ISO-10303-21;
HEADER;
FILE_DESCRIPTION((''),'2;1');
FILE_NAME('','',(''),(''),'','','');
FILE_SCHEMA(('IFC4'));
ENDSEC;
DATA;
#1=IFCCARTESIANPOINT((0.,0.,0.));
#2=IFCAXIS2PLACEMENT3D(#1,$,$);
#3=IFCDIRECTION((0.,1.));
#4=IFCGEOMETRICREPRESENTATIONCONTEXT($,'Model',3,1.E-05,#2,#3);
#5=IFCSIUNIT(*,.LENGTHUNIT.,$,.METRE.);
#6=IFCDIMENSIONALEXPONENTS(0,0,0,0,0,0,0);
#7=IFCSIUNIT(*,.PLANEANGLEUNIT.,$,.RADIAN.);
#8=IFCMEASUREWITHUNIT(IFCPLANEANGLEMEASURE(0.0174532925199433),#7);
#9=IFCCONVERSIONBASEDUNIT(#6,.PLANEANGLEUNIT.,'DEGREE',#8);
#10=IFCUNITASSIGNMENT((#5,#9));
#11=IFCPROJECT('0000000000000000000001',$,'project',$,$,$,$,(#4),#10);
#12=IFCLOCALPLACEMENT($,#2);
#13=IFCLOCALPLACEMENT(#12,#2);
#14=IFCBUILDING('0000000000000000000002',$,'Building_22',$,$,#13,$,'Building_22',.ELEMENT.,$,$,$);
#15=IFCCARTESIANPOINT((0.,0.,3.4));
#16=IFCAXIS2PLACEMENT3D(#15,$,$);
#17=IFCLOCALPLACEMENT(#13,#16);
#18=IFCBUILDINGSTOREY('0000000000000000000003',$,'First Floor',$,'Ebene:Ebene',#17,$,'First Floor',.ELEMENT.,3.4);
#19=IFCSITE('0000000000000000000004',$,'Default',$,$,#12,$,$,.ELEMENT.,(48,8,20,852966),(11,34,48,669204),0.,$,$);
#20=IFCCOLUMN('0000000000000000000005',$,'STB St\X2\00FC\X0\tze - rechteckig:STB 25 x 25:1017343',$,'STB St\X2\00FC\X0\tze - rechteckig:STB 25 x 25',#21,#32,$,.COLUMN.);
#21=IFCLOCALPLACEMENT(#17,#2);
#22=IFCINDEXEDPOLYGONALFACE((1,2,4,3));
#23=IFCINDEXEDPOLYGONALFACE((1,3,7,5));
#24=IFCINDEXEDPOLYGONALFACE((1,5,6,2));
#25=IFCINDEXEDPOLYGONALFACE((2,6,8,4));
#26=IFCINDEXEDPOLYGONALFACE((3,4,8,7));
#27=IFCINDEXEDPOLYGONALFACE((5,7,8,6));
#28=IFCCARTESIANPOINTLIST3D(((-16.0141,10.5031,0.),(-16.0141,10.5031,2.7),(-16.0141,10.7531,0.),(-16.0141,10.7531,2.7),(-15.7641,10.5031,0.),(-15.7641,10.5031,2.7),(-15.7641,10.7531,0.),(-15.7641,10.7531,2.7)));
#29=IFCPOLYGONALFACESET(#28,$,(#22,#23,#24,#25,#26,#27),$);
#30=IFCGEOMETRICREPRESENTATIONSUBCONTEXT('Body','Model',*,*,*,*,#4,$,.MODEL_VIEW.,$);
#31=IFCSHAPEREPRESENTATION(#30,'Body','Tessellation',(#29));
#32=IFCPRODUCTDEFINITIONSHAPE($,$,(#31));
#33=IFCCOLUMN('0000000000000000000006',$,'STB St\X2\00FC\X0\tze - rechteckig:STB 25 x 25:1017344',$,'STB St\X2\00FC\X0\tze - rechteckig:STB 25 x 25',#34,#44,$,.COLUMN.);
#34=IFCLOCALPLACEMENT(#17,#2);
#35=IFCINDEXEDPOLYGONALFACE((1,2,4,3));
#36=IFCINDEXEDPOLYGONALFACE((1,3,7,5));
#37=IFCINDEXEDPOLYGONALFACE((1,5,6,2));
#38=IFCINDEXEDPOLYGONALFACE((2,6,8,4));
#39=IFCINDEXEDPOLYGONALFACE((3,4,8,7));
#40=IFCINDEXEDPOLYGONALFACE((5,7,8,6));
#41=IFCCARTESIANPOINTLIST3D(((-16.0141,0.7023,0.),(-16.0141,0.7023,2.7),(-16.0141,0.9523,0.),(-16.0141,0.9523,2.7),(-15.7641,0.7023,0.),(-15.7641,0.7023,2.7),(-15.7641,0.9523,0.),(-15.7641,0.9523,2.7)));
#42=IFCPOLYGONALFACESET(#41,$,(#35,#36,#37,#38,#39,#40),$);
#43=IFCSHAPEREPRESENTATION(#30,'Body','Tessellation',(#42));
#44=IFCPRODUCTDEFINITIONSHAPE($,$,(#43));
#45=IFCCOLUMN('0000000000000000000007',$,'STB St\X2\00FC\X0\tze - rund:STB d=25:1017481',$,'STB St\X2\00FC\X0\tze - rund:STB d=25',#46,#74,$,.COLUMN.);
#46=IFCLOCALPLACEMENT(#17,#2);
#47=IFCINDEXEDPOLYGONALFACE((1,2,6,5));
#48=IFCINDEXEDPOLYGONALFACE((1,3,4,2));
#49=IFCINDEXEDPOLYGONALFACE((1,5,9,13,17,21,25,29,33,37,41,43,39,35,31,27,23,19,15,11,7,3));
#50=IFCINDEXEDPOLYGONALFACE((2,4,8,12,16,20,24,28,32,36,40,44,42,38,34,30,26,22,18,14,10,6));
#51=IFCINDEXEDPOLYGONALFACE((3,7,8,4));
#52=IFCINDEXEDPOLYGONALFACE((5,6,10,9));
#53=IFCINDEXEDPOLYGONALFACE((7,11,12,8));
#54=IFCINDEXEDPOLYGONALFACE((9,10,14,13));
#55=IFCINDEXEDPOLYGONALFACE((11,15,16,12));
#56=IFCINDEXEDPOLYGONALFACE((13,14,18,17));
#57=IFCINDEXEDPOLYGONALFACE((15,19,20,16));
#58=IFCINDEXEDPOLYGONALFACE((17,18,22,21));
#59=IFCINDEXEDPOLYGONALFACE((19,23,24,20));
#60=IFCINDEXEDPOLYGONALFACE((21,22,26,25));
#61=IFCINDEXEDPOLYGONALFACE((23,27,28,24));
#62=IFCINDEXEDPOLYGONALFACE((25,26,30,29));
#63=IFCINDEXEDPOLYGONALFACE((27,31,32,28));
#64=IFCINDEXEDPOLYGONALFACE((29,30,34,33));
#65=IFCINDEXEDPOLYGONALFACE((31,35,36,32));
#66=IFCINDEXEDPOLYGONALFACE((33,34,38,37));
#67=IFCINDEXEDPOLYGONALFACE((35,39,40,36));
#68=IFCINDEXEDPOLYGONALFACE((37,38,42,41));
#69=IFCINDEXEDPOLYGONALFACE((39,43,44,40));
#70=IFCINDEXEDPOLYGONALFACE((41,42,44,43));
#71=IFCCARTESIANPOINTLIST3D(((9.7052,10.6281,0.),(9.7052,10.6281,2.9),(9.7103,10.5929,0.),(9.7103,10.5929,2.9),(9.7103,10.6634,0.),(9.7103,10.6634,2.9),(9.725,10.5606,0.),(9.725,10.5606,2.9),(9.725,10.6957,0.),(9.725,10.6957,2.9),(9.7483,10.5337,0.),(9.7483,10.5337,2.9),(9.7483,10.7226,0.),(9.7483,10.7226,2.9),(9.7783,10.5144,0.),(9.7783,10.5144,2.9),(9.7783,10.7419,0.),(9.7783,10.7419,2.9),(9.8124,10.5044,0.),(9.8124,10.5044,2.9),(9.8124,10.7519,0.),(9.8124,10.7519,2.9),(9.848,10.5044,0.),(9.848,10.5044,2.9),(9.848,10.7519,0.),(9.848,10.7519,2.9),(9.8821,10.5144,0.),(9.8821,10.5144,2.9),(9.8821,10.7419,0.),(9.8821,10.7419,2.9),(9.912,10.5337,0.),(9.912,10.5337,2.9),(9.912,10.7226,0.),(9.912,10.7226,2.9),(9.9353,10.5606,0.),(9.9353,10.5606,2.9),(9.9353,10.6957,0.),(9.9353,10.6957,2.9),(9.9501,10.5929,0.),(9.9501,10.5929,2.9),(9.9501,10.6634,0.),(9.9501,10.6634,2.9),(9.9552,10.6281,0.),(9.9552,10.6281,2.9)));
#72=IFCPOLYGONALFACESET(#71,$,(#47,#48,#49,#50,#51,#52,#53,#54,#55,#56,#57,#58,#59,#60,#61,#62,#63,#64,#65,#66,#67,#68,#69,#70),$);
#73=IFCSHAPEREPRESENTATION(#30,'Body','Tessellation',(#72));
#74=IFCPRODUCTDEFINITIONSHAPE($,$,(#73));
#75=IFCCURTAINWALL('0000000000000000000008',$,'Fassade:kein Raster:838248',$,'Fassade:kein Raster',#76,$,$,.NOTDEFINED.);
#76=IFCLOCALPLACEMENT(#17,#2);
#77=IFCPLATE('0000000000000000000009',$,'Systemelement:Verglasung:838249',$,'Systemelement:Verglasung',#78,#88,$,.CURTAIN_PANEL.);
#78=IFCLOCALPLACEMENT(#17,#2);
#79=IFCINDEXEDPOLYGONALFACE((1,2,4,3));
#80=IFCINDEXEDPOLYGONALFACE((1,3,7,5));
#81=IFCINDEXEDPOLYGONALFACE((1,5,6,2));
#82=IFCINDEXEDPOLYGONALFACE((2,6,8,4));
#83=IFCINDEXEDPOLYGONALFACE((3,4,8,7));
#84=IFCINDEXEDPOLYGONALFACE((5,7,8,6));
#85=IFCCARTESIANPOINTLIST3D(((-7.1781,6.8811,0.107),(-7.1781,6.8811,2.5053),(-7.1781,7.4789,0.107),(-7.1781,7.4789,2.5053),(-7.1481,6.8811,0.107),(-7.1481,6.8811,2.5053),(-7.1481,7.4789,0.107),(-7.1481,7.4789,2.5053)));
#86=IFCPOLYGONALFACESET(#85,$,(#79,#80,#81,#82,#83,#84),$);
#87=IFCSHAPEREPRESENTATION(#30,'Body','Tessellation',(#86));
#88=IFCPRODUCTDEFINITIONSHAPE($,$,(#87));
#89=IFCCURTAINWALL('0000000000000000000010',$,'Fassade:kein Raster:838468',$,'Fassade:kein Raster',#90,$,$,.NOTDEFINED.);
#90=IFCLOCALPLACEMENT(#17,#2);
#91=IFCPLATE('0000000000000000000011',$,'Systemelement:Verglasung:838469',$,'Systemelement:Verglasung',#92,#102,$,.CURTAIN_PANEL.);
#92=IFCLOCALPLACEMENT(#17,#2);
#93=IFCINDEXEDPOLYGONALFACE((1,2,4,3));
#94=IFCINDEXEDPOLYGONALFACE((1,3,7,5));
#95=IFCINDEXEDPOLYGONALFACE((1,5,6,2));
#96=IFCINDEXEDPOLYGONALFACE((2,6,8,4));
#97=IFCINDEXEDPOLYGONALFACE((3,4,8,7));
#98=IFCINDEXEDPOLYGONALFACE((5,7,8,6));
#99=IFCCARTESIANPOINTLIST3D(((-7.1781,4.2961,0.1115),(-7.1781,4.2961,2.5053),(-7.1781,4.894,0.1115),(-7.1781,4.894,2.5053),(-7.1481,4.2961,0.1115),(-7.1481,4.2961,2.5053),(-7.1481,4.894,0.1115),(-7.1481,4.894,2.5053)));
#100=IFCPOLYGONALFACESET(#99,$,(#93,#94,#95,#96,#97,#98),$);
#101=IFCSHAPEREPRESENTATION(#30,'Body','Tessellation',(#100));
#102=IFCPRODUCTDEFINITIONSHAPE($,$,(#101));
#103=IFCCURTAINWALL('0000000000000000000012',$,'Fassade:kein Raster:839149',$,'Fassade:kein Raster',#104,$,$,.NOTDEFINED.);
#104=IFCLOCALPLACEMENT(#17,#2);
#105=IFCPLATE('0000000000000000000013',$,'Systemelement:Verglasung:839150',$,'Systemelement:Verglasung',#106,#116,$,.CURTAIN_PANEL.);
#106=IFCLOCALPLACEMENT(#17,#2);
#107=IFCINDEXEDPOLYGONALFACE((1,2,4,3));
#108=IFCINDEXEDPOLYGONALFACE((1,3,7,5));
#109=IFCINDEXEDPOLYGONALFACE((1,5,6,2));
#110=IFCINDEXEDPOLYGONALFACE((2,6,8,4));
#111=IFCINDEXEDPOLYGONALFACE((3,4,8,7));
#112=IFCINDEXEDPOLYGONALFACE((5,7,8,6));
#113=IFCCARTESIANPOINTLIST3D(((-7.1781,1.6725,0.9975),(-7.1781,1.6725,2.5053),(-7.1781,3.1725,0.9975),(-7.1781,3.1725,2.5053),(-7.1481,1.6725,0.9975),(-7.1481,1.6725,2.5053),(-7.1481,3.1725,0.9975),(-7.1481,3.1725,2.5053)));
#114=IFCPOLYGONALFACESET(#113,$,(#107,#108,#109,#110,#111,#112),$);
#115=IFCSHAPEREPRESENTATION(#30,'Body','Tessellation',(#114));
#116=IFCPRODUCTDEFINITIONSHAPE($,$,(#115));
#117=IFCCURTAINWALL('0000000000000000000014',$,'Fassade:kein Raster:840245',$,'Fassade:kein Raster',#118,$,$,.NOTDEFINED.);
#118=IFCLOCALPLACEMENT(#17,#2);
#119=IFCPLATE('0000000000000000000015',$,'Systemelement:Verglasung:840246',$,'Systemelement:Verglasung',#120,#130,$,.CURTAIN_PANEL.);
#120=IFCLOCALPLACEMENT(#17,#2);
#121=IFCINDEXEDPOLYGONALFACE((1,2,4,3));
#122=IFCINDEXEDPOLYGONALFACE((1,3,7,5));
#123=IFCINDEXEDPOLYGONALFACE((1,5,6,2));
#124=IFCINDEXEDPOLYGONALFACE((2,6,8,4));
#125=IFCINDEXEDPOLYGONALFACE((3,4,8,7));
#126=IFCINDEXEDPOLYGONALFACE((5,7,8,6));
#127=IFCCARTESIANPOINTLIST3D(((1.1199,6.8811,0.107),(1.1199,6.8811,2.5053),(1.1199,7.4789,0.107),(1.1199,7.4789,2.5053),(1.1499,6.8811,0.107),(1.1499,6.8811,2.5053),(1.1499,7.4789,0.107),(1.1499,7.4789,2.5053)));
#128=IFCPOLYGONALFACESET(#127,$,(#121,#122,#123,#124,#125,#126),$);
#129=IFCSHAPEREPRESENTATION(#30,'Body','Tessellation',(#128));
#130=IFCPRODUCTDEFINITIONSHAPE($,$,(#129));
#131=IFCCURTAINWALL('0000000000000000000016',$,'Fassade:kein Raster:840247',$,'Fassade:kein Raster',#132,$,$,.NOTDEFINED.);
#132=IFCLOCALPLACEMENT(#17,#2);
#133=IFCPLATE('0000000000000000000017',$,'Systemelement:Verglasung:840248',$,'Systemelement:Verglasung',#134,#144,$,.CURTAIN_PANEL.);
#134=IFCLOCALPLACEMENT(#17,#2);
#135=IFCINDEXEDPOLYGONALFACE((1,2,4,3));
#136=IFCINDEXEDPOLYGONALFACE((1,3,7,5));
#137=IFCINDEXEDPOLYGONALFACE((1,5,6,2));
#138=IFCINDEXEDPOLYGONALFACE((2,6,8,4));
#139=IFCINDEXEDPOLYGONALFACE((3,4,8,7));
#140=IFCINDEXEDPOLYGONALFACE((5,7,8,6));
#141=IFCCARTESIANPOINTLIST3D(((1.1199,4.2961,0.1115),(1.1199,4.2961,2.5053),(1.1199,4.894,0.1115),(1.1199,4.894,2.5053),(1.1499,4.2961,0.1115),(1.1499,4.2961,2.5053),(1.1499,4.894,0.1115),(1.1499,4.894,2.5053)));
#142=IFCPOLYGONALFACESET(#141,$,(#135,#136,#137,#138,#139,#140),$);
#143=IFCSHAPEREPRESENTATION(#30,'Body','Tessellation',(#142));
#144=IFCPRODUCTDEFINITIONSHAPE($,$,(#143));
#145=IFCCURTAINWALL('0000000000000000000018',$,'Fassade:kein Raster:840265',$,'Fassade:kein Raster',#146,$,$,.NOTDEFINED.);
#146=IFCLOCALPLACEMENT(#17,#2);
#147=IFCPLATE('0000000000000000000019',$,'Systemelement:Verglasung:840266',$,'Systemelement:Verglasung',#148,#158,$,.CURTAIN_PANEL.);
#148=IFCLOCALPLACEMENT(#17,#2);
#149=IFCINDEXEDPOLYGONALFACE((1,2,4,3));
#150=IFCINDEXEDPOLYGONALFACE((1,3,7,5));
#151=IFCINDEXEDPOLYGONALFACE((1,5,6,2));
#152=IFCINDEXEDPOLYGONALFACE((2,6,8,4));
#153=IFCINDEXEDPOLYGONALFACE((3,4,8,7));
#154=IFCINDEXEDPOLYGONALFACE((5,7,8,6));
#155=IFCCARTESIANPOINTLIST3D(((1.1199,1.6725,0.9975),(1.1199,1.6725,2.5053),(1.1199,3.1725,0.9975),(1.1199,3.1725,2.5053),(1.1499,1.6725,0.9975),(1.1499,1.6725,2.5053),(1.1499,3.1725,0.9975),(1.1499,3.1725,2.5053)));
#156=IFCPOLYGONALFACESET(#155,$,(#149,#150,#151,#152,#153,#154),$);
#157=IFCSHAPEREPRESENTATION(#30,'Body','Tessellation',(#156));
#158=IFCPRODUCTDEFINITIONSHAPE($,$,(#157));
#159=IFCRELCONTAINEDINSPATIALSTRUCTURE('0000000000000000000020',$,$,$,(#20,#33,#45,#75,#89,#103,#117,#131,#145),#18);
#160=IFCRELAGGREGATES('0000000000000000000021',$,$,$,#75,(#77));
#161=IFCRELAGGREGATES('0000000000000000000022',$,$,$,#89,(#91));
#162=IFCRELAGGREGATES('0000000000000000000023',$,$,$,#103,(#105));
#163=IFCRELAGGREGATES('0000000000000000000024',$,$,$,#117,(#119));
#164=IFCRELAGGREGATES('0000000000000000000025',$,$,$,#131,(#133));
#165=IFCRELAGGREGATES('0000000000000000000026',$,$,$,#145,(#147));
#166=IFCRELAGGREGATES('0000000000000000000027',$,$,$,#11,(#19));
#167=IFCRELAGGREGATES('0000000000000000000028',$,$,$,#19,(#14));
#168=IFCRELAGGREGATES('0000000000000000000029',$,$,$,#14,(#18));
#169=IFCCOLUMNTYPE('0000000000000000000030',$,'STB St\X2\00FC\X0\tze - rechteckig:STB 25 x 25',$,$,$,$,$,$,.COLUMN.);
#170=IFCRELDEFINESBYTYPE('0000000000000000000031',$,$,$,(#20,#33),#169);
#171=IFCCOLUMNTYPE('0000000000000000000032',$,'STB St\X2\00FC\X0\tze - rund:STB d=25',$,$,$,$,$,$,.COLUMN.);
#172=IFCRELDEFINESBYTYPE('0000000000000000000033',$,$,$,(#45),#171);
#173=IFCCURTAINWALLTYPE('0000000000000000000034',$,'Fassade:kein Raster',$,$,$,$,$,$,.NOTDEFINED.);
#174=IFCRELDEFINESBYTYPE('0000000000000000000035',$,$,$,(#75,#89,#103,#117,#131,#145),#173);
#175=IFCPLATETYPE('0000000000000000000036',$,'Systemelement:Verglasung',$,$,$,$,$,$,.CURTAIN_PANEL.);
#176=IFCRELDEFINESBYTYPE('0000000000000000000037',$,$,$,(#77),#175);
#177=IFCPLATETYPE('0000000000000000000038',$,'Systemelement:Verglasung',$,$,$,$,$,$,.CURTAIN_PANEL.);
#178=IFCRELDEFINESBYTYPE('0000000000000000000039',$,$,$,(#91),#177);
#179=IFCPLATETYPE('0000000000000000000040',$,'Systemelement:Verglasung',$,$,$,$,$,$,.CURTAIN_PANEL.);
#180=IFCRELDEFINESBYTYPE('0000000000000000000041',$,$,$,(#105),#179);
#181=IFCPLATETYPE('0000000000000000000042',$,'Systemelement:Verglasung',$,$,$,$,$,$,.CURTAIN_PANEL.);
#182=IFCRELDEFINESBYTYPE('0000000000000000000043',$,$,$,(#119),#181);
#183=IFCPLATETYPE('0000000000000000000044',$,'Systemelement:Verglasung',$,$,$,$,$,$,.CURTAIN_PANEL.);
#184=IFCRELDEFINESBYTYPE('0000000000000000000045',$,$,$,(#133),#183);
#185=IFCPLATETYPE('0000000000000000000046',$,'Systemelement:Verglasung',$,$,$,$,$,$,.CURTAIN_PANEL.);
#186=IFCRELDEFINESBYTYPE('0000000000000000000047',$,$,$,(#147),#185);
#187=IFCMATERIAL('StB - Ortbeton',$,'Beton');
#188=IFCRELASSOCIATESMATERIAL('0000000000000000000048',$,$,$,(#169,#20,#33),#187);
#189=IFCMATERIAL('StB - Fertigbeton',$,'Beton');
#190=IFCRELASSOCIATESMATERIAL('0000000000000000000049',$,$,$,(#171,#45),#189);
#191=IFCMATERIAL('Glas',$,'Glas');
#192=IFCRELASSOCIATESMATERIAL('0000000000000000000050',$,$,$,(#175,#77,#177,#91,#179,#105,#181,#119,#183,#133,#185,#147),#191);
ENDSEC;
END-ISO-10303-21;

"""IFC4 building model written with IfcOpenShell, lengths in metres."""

from ifc_helpers import new_model, entity, si_unit, converted_unit, direction, frame, origin, place, context, subcontext, project, spatial, arc, indexed_curve, outline, extrude, source, transform, mapped, material, type_object, type_shapes, element, aggregate, save


model = new_model("IFC4")

# Units and contexts
model_context = context("Model", 3, precision=1e-05, world=origin(), true_north=direction((0.0, 1.0)))
body_context = subcontext(model_context, "Body", "Model", "MODEL_VIEW")
ifc_project = project(units=[si_unit("LENGTHUNIT", "METRE"), converted_unit("PLANEANGLEUNIT", "DEGREE", entity("IfcPlaneAngleMeasure", 0.0174532925199433), si_unit("PLANEANGLEUNIT", "RADIAN"), dimensions=[0, 0, 0, 0, 0, 0, 0])], contexts=[model_context])

# Site, building, storey
site_placement = place(None, origin())
site = spatial("IfcSite", under=ifc_project, at=site_placement, Name="Default", CompositionType="ELEMENT", RefLatitude=(48, 8, 20, 852966), RefLongitude=(11, 34, 48, 669204), RefElevation=0.0)
building_placement = place(site_placement, origin())
building = spatial("IfcBuilding", under=site, at=building_placement, Name="Building_22", LongName="Building_22", CompositionType="ELEMENT")
storey_placement = place(building_placement, frame((0.0, 0.0, 3.4)))
storey = spatial("IfcBuildingStorey", under=building, at=storey_placement, Name="First Floor", ObjectType="Ebene:Ebene", LongName="First Floor", CompositionType="ELEMENT", Elevation=3.4)

# Columns
ifc_material_1 = material(Name="StB - Ortbeton", Category="Beton")
column_type_1 = type_object("IfcColumnType", Name="STB Stütze - rechteckig:STB 25 x 25", PredefinedType="COLUMN", material=ifc_material_1)
shared_shape_1 = source(origin(), body_context, "Body", "SweptSolid", [
    extrude(outline(indexed_curve([(-0.125, -0.125), (0.125, -0.125), (0.125, 0.125), (-0.125, 0.125), (-0.125, -0.125)], self_intersect=False)), frame((0.0, 0.0, 3.4), z_axis=(0.0, 0.0, 1.0), x_axis=(-1.0, 0.0, 0.0)), (0.0, 0.0, 1.0), 2.7),
])
type_shapes(column_type_1, [shared_shape_1])
for number, where, name in (
    (1, (-15.8891, 10.6281, -3.4), "STB Stütze - rechteckig:STB 25 x 25:1017343"),
    (2, (-15.8891, 0.8273, -3.4), "STB Stütze - rechteckig:STB 25 x 25:1017344"),
):
    element("IfcColumn", number, at=place(storey_placement, frame(where)), inside=storey, type_object=column_type_1, material=ifc_material_1, Name=name, ObjectType="STB Stütze - rechteckig:STB 25 x 25", PredefinedType="COLUMN", context=body_context, shape_type="MappedRepresentation", body=[
        mapped(shared_shape_1, transform((0.0, 0.0, 0.0), scale=1.0)),
    ])
ifc_material_2 = material(Name="StB - Fertigbeton", Category="Beton")
column_type_2 = type_object("IfcColumnType", Name="STB Stütze - rund:STB d=25", PredefinedType="COLUMN", material=ifc_material_2)
shared_shape_2 = source(origin(), body_context, "Body", "SweptSolid", [
    extrude(outline(indexed_curve([(-0.125, 0.0), (0.0, -0.125), (0.125, 0.0), (0.0, 0.125)], segments=[arc(1, 2, 3), arc(3, 4, 1)], self_intersect=False)), frame((0.0, 0.0, 3.4)), (0.0, 0.0, 1.0), 2.9),
])
type_shapes(column_type_2, [shared_shape_2])
column_placement = place(storey_placement, frame((9.8302, 10.6281, -3.4), z_axis=(0.0, 0.0, 1.0), x_axis=(-1.0, 0.0, 0.0)))
element("IfcColumn", 3, at=column_placement, inside=storey, type_object=column_type_2, material=ifc_material_2, Name="STB Stütze - rund:STB d=25:1017481", ObjectType="STB Stütze - rund:STB d=25", PredefinedType="COLUMN", context=body_context, shape_type="MappedRepresentation", body=[
    mapped(shared_shape_2, transform((0.0, 0.0, 0.0), scale=1.0)),
])

# Curtain walls, plates
curtain_wall_type = type_object("IfcCurtainWallType", Name="Fassade:kein Raster", PredefinedType="NOTDEFINED")
curtain_wall_1_placement = place(storey_placement, frame((0.0, 0.0, -3.4)))
curtain_wall_1 = element("IfcCurtainWall", 4, at=curtain_wall_1_placement, inside=storey, type_object=curtain_wall_type, Name="Fassade:kein Raster:838248", ObjectType="Fassade:kein Raster", PredefinedType="NOTDEFINED")
ifc_material_3 = material(Name="Glas", Category="Glas")
plate_type_1 = type_object("IfcPlateType", Name="Systemelement:Verglasung", PredefinedType="CURTAIN_PANEL", material=ifc_material_3)
shared_shape_3 = source(origin(), body_context, "Body", "SweptSolid", [
    extrude(outline(indexed_curve([(-0.015, -0.2989), (0.015, -0.2989), (0.015, 0.2989), (-0.015, 0.2989), (-0.015, -0.2989)], self_intersect=False)), frame((0.0, 0.0, 0.0), z_axis=(0.0, 0.0, 1.0), x_axis=(0.0, 1.0, 0.0)), (0.0, 0.0, 1.0), 2.3983),
])
type_shapes(plate_type_1, [shared_shape_3])
plate_1_placement = place(curtain_wall_1_placement, frame((-7.1631, 7.18, 3.507), z_axis=(0.0, 0.0, 1.0), x_axis=(0.0, -1.0, 0.0)))
plate_1 = element("IfcPlate", 5, at=plate_1_placement, type_object=plate_type_1, material=ifc_material_3, Name="Systemelement:Verglasung:838249", ObjectType="Systemelement:Verglasung", PredefinedType="CURTAIN_PANEL", context=body_context, shape_type="MappedRepresentation", body=[
    mapped(shared_shape_3, transform((0.0, 0.0, 0.0), scale=1.0)),
])
aggregate(curtain_wall_1, [plate_1])
curtain_wall_2_placement = place(storey_placement, frame((0.0, 0.0, -3.4)))
curtain_wall_2 = element("IfcCurtainWall", 6, at=curtain_wall_2_placement, inside=storey, type_object=curtain_wall_type, Name="Fassade:kein Raster:838468", ObjectType="Fassade:kein Raster", PredefinedType="NOTDEFINED")
plate_type_2 = type_object("IfcPlateType", Name="Systemelement:Verglasung", PredefinedType="CURTAIN_PANEL", material=ifc_material_3)
shared_shape_4 = source(origin(), body_context, "Body", "SweptSolid", [
    extrude(outline(indexed_curve([(-0.015, -0.2989), (0.015, -0.2989), (0.015, 0.2989), (-0.015, 0.2989), (-0.015, -0.2989)], self_intersect=False)), frame((0.0, 0.0, 0.0), z_axis=(0.0, 0.0, 1.0), x_axis=(0.0, 1.0, 0.0)), (0.0, 0.0, 1.0), 2.3939),
])
type_shapes(plate_type_2, [shared_shape_4])
plate_2_placement = place(curtain_wall_2_placement, frame((-7.1631, 4.595, 3.5115), z_axis=(0.0, 0.0, 1.0), x_axis=(0.0, -1.0, 0.0)))
plate_2 = element("IfcPlate", 7, at=plate_2_placement, type_object=plate_type_2, material=ifc_material_3, Name="Systemelement:Verglasung:838469", ObjectType="Systemelement:Verglasung", PredefinedType="CURTAIN_PANEL", context=body_context, shape_type="MappedRepresentation", body=[
    mapped(shared_shape_4, transform((0.0, 0.0, 0.0), scale=1.0)),
])
aggregate(curtain_wall_2, [plate_2])
curtain_wall_3_placement = place(storey_placement, frame((0.0, 0.0, -3.4)))
curtain_wall_3 = element("IfcCurtainWall", 8, at=curtain_wall_3_placement, inside=storey, type_object=curtain_wall_type, Name="Fassade:kein Raster:839149", ObjectType="Fassade:kein Raster", PredefinedType="NOTDEFINED")
plate_type_3 = type_object("IfcPlateType", Name="Systemelement:Verglasung", PredefinedType="CURTAIN_PANEL", material=ifc_material_3)
shared_shape_5 = source(origin(), body_context, "Body", "SweptSolid", [
    extrude(outline(indexed_curve([(-0.015, -0.75), (0.015, -0.75), (0.015, 0.75), (-0.015, 0.75), (-0.015, -0.75)], self_intersect=False)), frame((0.0, 0.0, 0.0), z_axis=(0.0, 0.0, 1.0), x_axis=(0.0, 1.0, 0.0)), (0.0, 0.0, 1.0), 1.5079),
])
type_shapes(plate_type_3, [shared_shape_5])
plate_3_placement = place(curtain_wall_3_placement, frame((-7.1631, 2.4225, 4.3975), z_axis=(0.0, 0.0, 1.0), x_axis=(0.0, -1.0, 0.0)))
plate_3 = element("IfcPlate", 9, at=plate_3_placement, type_object=plate_type_3, material=ifc_material_3, Name="Systemelement:Verglasung:839150", ObjectType="Systemelement:Verglasung", PredefinedType="CURTAIN_PANEL", context=body_context, shape_type="MappedRepresentation", body=[
    mapped(shared_shape_5, transform((0.0, 0.0, 0.0), scale=1.0)),
])
aggregate(curtain_wall_3, [plate_3])
curtain_wall_4_placement = place(storey_placement, frame((0.0, 0.0, -3.4)))
curtain_wall_4 = element("IfcCurtainWall", 10, at=curtain_wall_4_placement, inside=storey, type_object=curtain_wall_type, Name="Fassade:kein Raster:840245", ObjectType="Fassade:kein Raster", PredefinedType="NOTDEFINED")
plate_type_4 = type_object("IfcPlateType", Name="Systemelement:Verglasung", PredefinedType="CURTAIN_PANEL", material=ifc_material_3)
shared_shape_6 = source(origin(), body_context, "Body", "SweptSolid", [
    extrude(outline(indexed_curve([(-0.015, -0.2989), (0.015, -0.2989), (0.015, 0.2989), (-0.015, 0.2989), (-0.015, -0.2989)], self_intersect=False)), frame((0.0, 0.0, 0.0), z_axis=(0.0, 0.0, 1.0), x_axis=(0.0, 1.0, 0.0)), (0.0, 0.0, 1.0), 2.3983),
])
type_shapes(plate_type_4, [shared_shape_6])
plate_4_placement = place(curtain_wall_4_placement, frame((1.1349, 7.18, 3.507), z_axis=(0.0, 0.0, 1.0), x_axis=(0.0, -1.0, 0.0)))
plate_4 = element("IfcPlate", 11, at=plate_4_placement, type_object=plate_type_4, material=ifc_material_3, Name="Systemelement:Verglasung:840246", ObjectType="Systemelement:Verglasung", PredefinedType="CURTAIN_PANEL", context=body_context, shape_type="MappedRepresentation", body=[
    mapped(shared_shape_6, transform((0.0, 0.0, 0.0), scale=1.0)),
])
aggregate(curtain_wall_4, [plate_4])
curtain_wall_5_placement = place(storey_placement, frame((0.0, 0.0, -3.4)))
curtain_wall_5 = element("IfcCurtainWall", 12, at=curtain_wall_5_placement, inside=storey, type_object=curtain_wall_type, Name="Fassade:kein Raster:840247", ObjectType="Fassade:kein Raster", PredefinedType="NOTDEFINED")
plate_type_5 = type_object("IfcPlateType", Name="Systemelement:Verglasung", PredefinedType="CURTAIN_PANEL", material=ifc_material_3)
shared_shape_7 = source(origin(), body_context, "Body", "SweptSolid", [
    extrude(outline(indexed_curve([(-0.015, -0.2989), (0.015, -0.2989), (0.015, 0.2989), (-0.015, 0.2989), (-0.015, -0.2989)], self_intersect=False)), frame((0.0, 0.0, 0.0), z_axis=(0.0, 0.0, 1.0), x_axis=(0.0, 1.0, 0.0)), (0.0, 0.0, 1.0), 2.3939),
])
type_shapes(plate_type_5, [shared_shape_7])
plate_5_placement = place(curtain_wall_5_placement, frame((1.1349, 4.595, 3.5115), z_axis=(0.0, 0.0, 1.0), x_axis=(0.0, -1.0, 0.0)))
plate_5 = element("IfcPlate", 13, at=plate_5_placement, type_object=plate_type_5, material=ifc_material_3, Name="Systemelement:Verglasung:840248", ObjectType="Systemelement:Verglasung", PredefinedType="CURTAIN_PANEL", context=body_context, shape_type="MappedRepresentation", body=[
    mapped(shared_shape_7, transform((0.0, 0.0, 0.0), scale=1.0)),
])
aggregate(curtain_wall_5, [plate_5])
curtain_wall_6_placement = place(storey_placement, frame((0.0, 0.0, -3.4)))
curtain_wall_6 = element("IfcCurtainWall", 14, at=curtain_wall_6_placement, inside=storey, type_object=curtain_wall_type, Name="Fassade:kein Raster:840265", ObjectType="Fassade:kein Raster", PredefinedType="NOTDEFINED")
plate_type_6 = type_object("IfcPlateType", Name="Systemelement:Verglasung", PredefinedType="CURTAIN_PANEL", material=ifc_material_3)
shared_shape_8 = source(origin(), body_context, "Body", "SweptSolid", [
    extrude(outline(indexed_curve([(-0.015, -0.75), (0.015, -0.75), (0.015, 0.75), (-0.015, 0.75), (-0.015, -0.75)], self_intersect=False)), frame((0.0, 0.0, 0.0), z_axis=(0.0, 0.0, 1.0), x_axis=(0.0, 1.0, 0.0)), (0.0, 0.0, 1.0), 1.5079),
])
type_shapes(plate_type_6, [shared_shape_8])
plate_6_placement = place(curtain_wall_6_placement, frame((1.1349, 2.4225, 4.3975), z_axis=(0.0, 0.0, 1.0), x_axis=(0.0, -1.0, 0.0)))
plate_6 = element("IfcPlate", 15, at=plate_6_placement, type_object=plate_type_6, material=ifc_material_3, Name="Systemelement:Verglasung:840266", ObjectType="Systemelement:Verglasung", PredefinedType="CURTAIN_PANEL", context=body_context, shape_type="MappedRepresentation", body=[
    mapped(shared_shape_8, transform((0.0, 0.0, 0.0), scale=1.0)),
])
aggregate(curtain_wall_6, [plate_6])

save(model, "model.ifc")
